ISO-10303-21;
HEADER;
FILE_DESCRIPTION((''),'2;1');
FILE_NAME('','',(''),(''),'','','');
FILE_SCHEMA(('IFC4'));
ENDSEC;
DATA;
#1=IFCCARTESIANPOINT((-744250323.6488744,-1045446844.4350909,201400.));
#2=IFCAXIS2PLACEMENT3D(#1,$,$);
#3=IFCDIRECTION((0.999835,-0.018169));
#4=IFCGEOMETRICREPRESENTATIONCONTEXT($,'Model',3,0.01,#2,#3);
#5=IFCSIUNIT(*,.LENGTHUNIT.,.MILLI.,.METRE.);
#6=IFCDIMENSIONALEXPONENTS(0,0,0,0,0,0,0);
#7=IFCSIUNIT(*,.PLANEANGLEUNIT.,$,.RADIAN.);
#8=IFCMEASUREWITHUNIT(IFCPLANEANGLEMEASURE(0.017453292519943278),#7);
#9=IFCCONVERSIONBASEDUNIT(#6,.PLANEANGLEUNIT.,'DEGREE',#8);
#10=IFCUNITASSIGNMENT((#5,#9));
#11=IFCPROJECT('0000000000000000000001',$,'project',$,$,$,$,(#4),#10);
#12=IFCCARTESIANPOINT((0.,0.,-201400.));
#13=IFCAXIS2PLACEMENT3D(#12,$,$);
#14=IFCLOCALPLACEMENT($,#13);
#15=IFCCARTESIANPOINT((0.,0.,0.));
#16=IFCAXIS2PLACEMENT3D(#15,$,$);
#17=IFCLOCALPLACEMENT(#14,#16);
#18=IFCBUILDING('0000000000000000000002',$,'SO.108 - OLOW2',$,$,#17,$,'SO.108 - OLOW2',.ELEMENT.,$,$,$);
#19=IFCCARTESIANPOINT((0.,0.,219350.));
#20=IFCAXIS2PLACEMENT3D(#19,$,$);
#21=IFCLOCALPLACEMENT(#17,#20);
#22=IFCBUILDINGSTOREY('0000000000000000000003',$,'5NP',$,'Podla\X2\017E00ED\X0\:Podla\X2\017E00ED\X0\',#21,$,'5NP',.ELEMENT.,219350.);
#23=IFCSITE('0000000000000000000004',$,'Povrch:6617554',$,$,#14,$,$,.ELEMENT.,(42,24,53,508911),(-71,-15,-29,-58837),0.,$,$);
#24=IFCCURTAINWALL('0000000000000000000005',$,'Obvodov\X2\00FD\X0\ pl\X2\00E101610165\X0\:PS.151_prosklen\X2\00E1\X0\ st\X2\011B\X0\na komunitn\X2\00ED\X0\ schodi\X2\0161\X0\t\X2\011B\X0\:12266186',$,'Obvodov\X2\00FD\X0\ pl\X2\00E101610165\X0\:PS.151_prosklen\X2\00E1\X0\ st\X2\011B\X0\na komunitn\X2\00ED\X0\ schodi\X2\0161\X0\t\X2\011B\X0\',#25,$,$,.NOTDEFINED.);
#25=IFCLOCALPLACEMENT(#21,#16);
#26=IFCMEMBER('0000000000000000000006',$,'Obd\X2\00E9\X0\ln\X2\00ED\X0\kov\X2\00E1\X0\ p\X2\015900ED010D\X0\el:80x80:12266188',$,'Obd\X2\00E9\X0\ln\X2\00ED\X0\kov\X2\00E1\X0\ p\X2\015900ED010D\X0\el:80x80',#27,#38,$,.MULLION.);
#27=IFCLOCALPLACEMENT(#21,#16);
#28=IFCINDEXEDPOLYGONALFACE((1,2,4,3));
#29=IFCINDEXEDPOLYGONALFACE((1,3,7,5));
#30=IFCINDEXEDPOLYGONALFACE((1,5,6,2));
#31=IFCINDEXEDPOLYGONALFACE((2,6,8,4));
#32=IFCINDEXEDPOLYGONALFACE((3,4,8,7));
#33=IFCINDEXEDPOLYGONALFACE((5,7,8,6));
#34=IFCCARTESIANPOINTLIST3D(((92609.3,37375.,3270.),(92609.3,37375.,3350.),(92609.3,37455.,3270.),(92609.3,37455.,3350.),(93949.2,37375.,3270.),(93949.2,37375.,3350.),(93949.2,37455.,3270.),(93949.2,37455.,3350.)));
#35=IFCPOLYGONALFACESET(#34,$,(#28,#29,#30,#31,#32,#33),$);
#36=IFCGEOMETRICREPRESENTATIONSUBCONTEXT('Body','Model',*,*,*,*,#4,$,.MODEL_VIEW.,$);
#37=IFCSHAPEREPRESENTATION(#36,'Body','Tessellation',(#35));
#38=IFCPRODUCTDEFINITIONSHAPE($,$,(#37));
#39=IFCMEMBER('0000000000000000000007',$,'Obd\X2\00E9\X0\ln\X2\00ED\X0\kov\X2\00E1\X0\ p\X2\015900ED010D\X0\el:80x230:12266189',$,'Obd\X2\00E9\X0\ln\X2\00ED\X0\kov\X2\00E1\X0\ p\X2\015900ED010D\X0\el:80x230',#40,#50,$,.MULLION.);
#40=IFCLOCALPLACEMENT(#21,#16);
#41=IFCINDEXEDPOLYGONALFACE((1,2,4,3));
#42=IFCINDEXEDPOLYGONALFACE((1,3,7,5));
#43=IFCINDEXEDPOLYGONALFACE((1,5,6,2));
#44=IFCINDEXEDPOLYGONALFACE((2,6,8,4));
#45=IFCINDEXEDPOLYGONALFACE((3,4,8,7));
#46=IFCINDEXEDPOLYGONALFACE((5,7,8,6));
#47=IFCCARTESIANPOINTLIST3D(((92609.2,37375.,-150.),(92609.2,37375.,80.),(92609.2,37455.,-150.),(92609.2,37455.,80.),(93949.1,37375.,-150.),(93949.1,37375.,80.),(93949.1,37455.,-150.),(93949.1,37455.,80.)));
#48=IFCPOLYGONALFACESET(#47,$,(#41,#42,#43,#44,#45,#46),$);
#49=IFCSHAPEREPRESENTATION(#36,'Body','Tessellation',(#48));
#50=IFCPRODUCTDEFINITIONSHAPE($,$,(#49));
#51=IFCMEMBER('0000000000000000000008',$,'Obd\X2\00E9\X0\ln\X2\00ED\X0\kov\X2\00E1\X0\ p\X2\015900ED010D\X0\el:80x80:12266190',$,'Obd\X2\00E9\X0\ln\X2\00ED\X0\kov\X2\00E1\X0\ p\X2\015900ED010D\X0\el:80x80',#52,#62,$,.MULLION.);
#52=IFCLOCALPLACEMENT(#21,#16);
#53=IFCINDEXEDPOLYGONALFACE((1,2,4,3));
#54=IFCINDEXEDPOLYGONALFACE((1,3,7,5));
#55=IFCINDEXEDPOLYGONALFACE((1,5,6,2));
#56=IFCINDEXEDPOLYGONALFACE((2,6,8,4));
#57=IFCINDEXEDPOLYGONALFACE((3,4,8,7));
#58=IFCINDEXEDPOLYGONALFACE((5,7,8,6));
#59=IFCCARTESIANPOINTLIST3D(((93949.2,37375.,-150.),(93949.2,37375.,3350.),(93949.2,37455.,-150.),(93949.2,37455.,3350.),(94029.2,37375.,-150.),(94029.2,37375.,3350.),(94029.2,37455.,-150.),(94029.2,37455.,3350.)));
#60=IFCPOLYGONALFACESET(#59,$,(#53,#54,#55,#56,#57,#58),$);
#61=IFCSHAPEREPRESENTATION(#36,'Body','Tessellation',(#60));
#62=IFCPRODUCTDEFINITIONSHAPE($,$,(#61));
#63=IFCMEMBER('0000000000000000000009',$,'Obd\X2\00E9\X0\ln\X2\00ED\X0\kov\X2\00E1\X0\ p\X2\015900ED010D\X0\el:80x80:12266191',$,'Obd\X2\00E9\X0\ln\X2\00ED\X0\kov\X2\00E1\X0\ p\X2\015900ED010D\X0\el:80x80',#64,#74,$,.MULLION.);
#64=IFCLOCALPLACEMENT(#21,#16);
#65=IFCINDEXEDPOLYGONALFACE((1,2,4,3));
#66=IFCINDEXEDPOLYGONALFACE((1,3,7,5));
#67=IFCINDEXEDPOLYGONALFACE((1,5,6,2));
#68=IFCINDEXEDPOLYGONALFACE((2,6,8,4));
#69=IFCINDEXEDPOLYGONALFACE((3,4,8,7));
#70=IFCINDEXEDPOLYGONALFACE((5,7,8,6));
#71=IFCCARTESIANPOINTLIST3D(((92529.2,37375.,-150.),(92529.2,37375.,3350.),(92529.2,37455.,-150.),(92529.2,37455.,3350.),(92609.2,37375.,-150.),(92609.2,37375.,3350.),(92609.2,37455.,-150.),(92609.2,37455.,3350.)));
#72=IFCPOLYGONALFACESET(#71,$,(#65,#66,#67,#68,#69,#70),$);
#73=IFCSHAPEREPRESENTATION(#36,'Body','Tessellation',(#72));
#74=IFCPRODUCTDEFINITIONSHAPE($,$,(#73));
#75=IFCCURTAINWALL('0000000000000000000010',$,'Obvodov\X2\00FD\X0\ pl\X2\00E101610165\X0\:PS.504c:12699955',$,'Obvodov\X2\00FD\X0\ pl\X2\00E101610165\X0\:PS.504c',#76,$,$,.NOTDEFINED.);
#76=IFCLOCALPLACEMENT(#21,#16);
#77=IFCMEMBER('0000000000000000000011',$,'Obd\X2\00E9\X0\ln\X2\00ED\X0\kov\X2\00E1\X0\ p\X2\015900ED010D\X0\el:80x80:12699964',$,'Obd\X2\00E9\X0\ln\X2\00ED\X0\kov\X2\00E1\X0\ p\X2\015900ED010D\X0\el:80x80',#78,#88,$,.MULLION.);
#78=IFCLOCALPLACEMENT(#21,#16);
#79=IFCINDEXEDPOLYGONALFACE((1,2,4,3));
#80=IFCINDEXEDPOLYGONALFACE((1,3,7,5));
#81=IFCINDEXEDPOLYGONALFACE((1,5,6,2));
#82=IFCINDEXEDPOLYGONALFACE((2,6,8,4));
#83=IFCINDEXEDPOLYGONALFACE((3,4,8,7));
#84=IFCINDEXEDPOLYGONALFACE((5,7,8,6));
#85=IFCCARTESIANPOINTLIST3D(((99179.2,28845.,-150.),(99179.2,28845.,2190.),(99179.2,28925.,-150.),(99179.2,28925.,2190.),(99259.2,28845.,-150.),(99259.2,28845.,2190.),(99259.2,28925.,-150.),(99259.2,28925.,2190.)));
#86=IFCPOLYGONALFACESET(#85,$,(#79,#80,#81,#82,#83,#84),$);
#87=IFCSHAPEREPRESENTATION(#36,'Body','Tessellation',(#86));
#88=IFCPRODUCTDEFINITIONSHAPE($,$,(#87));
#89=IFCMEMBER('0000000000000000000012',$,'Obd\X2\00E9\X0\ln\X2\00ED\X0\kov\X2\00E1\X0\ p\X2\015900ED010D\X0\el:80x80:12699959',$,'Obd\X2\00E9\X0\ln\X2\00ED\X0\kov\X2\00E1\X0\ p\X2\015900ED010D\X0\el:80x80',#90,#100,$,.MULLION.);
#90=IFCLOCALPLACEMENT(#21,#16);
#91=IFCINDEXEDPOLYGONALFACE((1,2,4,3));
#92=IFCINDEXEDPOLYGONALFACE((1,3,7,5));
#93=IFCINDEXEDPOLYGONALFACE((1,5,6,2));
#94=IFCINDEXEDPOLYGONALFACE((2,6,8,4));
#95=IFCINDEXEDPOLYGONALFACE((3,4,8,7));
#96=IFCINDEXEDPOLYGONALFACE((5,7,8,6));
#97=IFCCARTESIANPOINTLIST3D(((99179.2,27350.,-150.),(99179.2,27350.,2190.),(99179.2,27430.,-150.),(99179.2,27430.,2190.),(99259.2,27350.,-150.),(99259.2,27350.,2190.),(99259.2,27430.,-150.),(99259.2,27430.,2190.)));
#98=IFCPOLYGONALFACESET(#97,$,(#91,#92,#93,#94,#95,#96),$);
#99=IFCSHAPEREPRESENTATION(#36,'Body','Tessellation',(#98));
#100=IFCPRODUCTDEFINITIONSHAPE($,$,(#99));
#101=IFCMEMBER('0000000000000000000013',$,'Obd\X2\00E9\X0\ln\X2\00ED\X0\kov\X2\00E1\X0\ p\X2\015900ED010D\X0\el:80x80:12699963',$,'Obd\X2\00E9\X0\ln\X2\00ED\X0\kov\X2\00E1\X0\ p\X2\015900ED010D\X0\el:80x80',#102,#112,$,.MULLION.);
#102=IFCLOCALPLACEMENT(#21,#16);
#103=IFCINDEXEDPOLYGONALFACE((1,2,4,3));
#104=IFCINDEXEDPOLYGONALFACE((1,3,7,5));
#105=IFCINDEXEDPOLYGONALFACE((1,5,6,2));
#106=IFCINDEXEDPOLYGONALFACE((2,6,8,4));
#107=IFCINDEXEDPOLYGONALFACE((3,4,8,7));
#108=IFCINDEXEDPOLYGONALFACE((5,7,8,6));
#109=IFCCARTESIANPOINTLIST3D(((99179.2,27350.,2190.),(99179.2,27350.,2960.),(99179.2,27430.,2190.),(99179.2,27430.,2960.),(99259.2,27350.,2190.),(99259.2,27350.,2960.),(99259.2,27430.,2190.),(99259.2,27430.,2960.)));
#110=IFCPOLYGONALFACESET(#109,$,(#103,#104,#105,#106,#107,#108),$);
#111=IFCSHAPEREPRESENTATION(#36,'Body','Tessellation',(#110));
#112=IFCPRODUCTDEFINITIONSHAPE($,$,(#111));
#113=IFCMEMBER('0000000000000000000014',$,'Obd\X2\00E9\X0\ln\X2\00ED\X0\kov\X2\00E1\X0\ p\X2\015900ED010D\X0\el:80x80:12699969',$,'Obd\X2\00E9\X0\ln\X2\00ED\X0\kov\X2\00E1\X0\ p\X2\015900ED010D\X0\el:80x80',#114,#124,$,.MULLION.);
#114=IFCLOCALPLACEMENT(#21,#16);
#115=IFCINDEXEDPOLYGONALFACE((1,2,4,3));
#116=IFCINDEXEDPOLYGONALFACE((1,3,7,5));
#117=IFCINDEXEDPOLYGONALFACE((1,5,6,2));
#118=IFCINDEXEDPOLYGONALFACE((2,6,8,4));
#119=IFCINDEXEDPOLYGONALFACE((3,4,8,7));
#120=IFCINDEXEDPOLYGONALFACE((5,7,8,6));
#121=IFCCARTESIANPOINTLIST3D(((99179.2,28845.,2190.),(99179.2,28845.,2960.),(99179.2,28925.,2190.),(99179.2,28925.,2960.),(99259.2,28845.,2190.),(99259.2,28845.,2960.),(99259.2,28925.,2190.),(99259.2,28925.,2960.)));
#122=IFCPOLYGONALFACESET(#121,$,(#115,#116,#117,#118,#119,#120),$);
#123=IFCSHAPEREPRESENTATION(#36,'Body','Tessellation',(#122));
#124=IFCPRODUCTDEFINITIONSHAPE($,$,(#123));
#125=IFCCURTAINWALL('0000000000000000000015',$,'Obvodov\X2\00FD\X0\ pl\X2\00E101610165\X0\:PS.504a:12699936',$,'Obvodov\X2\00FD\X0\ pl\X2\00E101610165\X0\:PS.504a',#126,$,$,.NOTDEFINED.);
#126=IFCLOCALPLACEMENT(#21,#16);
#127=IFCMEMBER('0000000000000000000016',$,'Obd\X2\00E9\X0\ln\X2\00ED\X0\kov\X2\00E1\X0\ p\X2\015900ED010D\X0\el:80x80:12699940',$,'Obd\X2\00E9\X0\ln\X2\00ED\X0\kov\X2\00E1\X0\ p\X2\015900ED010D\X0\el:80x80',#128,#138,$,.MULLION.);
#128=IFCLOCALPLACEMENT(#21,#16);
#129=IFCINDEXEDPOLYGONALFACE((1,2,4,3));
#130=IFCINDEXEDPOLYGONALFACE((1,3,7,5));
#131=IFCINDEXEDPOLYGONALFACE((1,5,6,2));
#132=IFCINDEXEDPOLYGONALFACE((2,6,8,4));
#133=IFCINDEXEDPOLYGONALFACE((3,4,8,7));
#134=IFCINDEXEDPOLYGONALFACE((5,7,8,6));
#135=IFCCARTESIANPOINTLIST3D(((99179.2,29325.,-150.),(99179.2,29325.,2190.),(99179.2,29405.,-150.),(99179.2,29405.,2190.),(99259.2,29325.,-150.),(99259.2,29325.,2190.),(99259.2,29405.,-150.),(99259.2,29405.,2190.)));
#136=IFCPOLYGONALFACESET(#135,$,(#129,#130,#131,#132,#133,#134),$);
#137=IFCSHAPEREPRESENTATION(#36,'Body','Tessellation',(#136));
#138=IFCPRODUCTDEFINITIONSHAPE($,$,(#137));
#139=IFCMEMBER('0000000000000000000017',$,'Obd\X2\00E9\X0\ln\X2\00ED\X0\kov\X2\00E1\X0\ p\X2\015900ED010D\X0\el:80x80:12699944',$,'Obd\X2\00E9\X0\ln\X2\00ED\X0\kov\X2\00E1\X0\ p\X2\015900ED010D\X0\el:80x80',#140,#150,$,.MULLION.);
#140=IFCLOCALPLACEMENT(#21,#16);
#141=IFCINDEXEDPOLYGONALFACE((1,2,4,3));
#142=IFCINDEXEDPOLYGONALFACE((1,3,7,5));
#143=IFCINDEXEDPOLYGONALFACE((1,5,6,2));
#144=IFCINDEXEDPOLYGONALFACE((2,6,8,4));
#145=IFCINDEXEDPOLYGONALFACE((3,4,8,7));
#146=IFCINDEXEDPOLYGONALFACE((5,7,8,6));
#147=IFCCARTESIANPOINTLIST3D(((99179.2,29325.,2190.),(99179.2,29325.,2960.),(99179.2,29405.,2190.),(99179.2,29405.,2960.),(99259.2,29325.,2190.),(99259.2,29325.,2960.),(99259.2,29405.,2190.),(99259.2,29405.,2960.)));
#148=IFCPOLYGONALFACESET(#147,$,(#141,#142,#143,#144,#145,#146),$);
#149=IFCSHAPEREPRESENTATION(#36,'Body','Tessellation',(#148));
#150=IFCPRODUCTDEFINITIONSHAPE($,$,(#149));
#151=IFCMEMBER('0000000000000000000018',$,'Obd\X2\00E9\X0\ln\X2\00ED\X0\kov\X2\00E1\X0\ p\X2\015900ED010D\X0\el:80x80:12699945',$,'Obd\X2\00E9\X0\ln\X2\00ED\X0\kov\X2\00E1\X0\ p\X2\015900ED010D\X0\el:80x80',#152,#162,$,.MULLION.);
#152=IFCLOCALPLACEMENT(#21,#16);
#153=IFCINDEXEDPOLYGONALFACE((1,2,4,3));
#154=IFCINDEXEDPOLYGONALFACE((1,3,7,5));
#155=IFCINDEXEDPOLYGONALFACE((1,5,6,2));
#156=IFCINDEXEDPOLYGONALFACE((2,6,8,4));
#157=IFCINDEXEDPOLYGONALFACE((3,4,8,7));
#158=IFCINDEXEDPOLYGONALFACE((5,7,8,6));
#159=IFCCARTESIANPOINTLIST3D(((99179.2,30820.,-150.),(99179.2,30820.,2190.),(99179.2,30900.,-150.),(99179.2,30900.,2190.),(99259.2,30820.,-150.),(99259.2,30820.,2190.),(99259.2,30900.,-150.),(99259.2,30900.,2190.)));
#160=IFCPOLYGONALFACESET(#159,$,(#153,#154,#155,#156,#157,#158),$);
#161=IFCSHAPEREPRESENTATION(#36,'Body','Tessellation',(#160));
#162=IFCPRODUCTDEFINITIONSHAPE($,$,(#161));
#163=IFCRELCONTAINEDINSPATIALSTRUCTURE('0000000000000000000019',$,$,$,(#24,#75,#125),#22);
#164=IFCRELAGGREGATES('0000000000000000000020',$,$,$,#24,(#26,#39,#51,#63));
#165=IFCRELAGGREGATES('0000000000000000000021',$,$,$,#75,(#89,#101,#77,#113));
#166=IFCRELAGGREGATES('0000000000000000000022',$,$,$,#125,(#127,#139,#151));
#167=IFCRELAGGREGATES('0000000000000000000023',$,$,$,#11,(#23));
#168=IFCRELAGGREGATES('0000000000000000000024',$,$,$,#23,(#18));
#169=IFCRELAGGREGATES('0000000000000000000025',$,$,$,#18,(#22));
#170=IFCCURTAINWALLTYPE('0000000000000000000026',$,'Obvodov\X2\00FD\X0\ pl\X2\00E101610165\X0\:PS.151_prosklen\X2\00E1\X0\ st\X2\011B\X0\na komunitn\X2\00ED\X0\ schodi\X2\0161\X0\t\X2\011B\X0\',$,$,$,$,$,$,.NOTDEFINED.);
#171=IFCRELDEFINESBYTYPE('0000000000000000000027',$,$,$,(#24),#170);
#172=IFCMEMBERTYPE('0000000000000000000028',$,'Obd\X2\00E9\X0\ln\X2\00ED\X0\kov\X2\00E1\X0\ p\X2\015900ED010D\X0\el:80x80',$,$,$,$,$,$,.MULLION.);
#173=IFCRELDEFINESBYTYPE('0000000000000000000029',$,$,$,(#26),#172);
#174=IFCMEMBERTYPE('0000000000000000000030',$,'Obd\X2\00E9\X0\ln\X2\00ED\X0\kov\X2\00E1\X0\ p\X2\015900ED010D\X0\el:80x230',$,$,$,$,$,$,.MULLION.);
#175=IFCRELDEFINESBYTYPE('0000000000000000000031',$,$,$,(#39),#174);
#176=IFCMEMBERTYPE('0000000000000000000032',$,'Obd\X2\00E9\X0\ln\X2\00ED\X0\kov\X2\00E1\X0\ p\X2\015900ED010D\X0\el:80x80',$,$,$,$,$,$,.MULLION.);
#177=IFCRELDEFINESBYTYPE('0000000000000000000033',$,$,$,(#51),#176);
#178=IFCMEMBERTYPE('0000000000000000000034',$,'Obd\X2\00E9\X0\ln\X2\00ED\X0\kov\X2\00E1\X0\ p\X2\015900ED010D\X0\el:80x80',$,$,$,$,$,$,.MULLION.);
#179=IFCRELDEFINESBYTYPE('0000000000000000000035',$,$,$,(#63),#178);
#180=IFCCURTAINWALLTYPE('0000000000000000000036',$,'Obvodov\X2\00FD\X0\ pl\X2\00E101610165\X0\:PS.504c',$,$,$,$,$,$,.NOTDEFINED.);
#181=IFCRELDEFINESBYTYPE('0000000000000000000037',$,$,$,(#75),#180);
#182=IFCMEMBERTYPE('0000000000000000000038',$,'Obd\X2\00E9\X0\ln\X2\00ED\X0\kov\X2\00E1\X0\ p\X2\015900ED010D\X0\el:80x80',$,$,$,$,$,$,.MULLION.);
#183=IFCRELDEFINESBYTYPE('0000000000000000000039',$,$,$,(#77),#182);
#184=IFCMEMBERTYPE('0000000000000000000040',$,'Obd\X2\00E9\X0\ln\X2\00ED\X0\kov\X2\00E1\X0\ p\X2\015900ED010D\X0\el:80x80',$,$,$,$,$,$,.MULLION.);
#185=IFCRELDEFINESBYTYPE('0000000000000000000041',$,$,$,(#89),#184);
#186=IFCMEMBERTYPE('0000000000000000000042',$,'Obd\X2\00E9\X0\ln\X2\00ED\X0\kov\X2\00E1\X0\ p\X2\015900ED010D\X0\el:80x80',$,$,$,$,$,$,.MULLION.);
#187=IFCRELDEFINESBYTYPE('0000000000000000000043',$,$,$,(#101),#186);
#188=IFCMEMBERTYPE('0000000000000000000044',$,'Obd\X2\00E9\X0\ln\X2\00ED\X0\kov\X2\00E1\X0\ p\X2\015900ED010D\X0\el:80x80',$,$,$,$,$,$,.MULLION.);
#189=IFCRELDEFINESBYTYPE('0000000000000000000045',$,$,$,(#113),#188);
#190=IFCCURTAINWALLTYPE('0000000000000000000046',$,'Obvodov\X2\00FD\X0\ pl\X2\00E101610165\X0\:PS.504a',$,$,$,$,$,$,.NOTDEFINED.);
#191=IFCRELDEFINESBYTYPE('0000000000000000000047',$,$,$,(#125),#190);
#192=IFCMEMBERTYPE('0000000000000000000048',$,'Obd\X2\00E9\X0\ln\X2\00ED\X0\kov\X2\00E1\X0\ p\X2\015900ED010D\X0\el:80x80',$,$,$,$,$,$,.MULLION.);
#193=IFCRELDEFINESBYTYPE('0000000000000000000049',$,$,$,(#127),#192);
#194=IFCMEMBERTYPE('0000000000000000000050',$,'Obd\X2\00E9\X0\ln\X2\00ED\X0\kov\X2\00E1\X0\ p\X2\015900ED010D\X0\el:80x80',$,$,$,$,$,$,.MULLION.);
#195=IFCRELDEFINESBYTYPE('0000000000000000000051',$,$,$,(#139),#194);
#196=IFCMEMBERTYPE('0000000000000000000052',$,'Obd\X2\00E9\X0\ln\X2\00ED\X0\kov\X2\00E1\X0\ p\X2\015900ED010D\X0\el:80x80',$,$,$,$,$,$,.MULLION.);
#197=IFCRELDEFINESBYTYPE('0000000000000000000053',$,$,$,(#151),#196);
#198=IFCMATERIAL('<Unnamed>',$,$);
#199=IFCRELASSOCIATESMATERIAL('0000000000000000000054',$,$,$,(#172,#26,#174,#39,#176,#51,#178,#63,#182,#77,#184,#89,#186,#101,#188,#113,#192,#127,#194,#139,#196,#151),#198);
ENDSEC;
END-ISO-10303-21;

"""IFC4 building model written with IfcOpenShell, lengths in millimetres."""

from ifc_helpers import new_model, entity, si_unit, converted_unit, direction, frame, origin, place, context, subcontext, project, spatial, indexed_curve, outline, extrude, source, transform, mapped, material, type_object, type_shapes, element, aggregate, save


model = new_model("IFC4")

# Units and contexts
model_context = context("Model", 3, precision=0.01, world=frame((-744250323.6488744, -1045446844.4350909, 201400.0)), true_north=direction((0.999835, -0.018169)))
body_context = subcontext(model_context, "Body", "Model", "MODEL_VIEW")
ifc_project = project(units=[si_unit("LENGTHUNIT", "METRE", prefix="MILLI"), converted_unit("PLANEANGLEUNIT", "DEGREE", entity("IfcPlaneAngleMeasure", 0.017453292519943278), si_unit("PLANEANGLEUNIT", "RADIAN"), dimensions=[0, 0, 0, 0, 0, 0, 0])], contexts=[model_context])

# Site, building, storey
site_placement = place(None, frame((0.0, 0.0, -201400.0)))
site = spatial("IfcSite", under=ifc_project, at=site_placement, Name="Povrch:6617554", CompositionType="ELEMENT", RefLatitude=(42, 24, 53, 508911), RefLongitude=(-71, -15, -29, -58837), RefElevation=0.0)
building_placement = place(site_placement, origin())
building = spatial("IfcBuilding", under=site, at=building_placement, Name="SO.108 - OLOW2", LongName="SO.108 - OLOW2", CompositionType="ELEMENT")
storey_placement = place(building_placement, frame((0.0, 0.0, 219350.0)))
storey = spatial("IfcBuildingStorey", under=building, at=storey_placement, Name="5NP", ObjectType="Podlaží:Podlaží", LongName="5NP", CompositionType="ELEMENT", Elevation=219350.0)

# Curtain walls, members
curtain_wall_type_1 = type_object("IfcCurtainWallType", Name="Obvodový plášť:PS.151_prosklená stěna komunitní schodiště", PredefinedType="NOTDEFINED")
curtain_wall_1_placement = place(storey_placement, frame((0.0, 0.0, -219350.0)))
curtain_wall_1 = element("IfcCurtainWall", 1, at=curtain_wall_1_placement, inside=storey, type_object=curtain_wall_type_1, Name="Obvodový plášť:PS.151_prosklená stěna komunitní schodiště:12266186", ObjectType="Obvodový plášť:PS.151_prosklená stěna komunitní schodiště", PredefinedType="NOTDEFINED")
ifc_material_1 = material(Name="<Unnamed>")
member_type_1 = type_object("IfcMemberType", Name="Obdélníková příčel:80x80", PredefinedType="MULLION", material=ifc_material_1)
shared_shape_1 = source(origin(), body_context, "Body", "SweptSolid", [
    extrude(outline(indexed_curve([(-40.0, -40.0), (40.0, -40.0), (40.0, 40.0), (-40.0, 40.0), (-40.0, -40.0)], self_intersect=False)), frame((-40.0, 0.0, -1339.9), z_axis=(0.0, 0.0, 1.0), x_axis=(-1.0, 0.0, 0.0)), (0.0, 0.0, 1.0), 1339.9),
])
type_shapes(member_type_1, [shared_shape_1])
member_1_placement = place(curtain_wall_1_placement, frame((93949.2, 37415.0, 222700.0), z_axis=(1.0, 0.0, 0.0), x_axis=(0.0, 0.0, 1.0)))
member_1 = element("IfcMember", 2, at=member_1_placement, type_object=member_type_1, material=ifc_material_1, Name="Obdélníková příčel:80x80:12266188", ObjectType="Obdélníková příčel:80x80", PredefinedType="MULLION", context=body_context, shape_type="MappedRepresentation", body=[
    mapped(shared_shape_1, transform((0.0, 0.0, 0.0), scale=1.0)),
])
member_type_2 = type_object("IfcMemberType", Name="Obdélníková příčel:80x230", PredefinedType="MULLION", material=ifc_material_1)
shared_shape_2 = source(origin(), body_context, "Body", "SweptSolid", [
    extrude(outline(indexed_curve([(-115.0, -40.0), (115.0, -40.0), (115.0, 40.0), (-115.0, 40.0), (-115.0, -40.0)], self_intersect=False)), frame((-115.0, 0.0, -1339.9), z_axis=(0.0, 0.0, 1.0), x_axis=(-1.0, 0.0, 0.0)), (0.0, 0.0, 1.0), 1339.9),
])
type_shapes(member_type_2, [shared_shape_2])
member_2_placement = place(curtain_wall_1_placement, frame((92609.2, 37415.0, 219200.0), z_axis=(-1.0, 0.0, 0.0), x_axis=(0.0, 0.0, -1.0)))
member_2 = element("IfcMember", 3, at=member_2_placement, type_object=member_type_2, material=ifc_material_1, Name="Obdélníková příčel:80x230:12266189", ObjectType="Obdélníková příčel:80x230", PredefinedType="MULLION", context=body_context, shape_type="MappedRepresentation", body=[
    mapped(shared_shape_2, transform((0.0, 0.0, 0.0), scale=1.0)),
])
member_type_3 = type_object("IfcMemberType", Name="Obdélníková příčel:80x80", PredefinedType="MULLION", material=ifc_material_1)
shared_shape_3 = source(origin(), body_context, "Body", "SweptSolid", [
    extrude(outline(indexed_curve([(-40.0, -40.0), (40.0, -40.0), (40.0, 40.0), (-40.0, 40.0), (-40.0, -40.0)], self_intersect=False)), frame((-40.0, 0.0, -3500.0), z_axis=(0.0, 0.0, 1.0), x_axis=(-1.0, 0.0, 0.0)), (0.0, 0.0, 1.0), 3500.0),
])
type_shapes(member_type_3, [shared_shape_3])
member_3_placement = place(curtain_wall_1_placement, frame((94029.2, 37415.0, 219200.0), z_axis=(0.0, 0.0, -1.0), x_axis=(1.0, 0.0, 0.0)))
member_3 = element("IfcMember", 4, at=member_3_placement, type_object=member_type_3, material=ifc_material_1, Name="Obdélníková příčel:80x80:12266190", ObjectType="Obdélníková příčel:80x80", PredefinedType="MULLION", context=body_context, shape_type="MappedRepresentation", body=[
    mapped(shared_shape_3, transform((0.0, 0.0, 0.0), scale=1.0)),
])
member_type_4 = type_object("IfcMemberType", Name="Obdélníková příčel:80x80", PredefinedType="MULLION", material=ifc_material_1)
shared_shape_4 = source(origin(), body_context, "Body", "SweptSolid", [
    extrude(outline(indexed_curve([(-40.0, -40.0), (40.0, -40.0), (40.0, 40.0), (-40.0, 40.0), (-40.0, -40.0)], self_intersect=False)), frame((-40.0, 0.0, -3500.0), z_axis=(0.0, 0.0, 1.0), x_axis=(-1.0, 0.0, 0.0)), (0.0, 0.0, 1.0), 3500.0),
])
type_shapes(member_type_4, [shared_shape_4])
member_4_placement = place(curtain_wall_1_placement, frame((92529.2, 37415.0, 222700.0), z_axis=(0.0, 0.0, 1.0), x_axis=(-1.0, 0.0, 0.0)))
member_4 = element("IfcMember", 5, at=member_4_placement, type_object=member_type_4, material=ifc_material_1, Name="Obdélníková příčel:80x80:12266191", ObjectType="Obdélníková příčel:80x80", PredefinedType="MULLION", context=body_context, shape_type="MappedRepresentation", body=[
    mapped(shared_shape_4, transform((0.0, 0.0, 0.0), scale=1.0)),
])
curtain_wall_type_2 = type_object("IfcCurtainWallType", Name="Obvodový plášť:PS.504c", PredefinedType="NOTDEFINED")
curtain_wall_2_placement = place(storey_placement, frame((0.0, 0.0, -219350.0)))
curtain_wall_2 = element("IfcCurtainWall", 6, at=curtain_wall_2_placement, inside=storey, type_object=curtain_wall_type_2, Name="Obvodový plášť:PS.504c:12699955", ObjectType="Obvodový plášť:PS.504c", PredefinedType="NOTDEFINED")
member_type_5 = type_object("IfcMemberType", Name="Obdélníková příčel:80x80", PredefinedType="MULLION", material=ifc_material_1)
shared_shape_5 = source(origin(), body_context, "Body", "SweptSolid", [
    extrude(outline(indexed_curve([(-40.0, -40.0), (40.0, -40.0), (40.0, 40.0), (-40.0, 40.0), (-40.0, -40.0)], self_intersect=False)), frame((-40.0, 0.0, -2340.0), z_axis=(0.0, 0.0, 1.0), x_axis=(-1.0, 0.0, 0.0)), (0.0, 0.0, 1.0), 2340.0),
])
type_shapes(member_type_5, [shared_shape_5])
member_5_placement = place(curtain_wall_2_placement, frame((99219.2, 28925.0, 221540.0), z_axis=(0.0, 0.0, 1.0), x_axis=(0.0, 1.0, 0.0)))
member_5 = element("IfcMember", 7, at=member_5_placement, type_object=member_type_5, material=ifc_material_1, Name="Obdélníková příčel:80x80:12699964", ObjectType="Obdélníková příčel:80x80", PredefinedType="MULLION", context=body_context, shape_type="MappedRepresentation", body=[
    mapped(shared_shape_5, transform((0.0, 0.0, 0.0), scale=1.0)),
])
member_type_6 = type_object("IfcMemberType", Name="Obdélníková příčel:80x80", PredefinedType="MULLION", material=ifc_material_1)
shared_shape_6 = source(origin(), body_context, "Body", "SweptSolid", [
    extrude(outline(indexed_curve([(-40.0, -40.0), (40.0, -40.0), (40.0, 40.0), (-40.0, 40.0), (-40.0, -40.0)], self_intersect=False)), frame((-40.0, 0.0, -2340.0), z_axis=(0.0, 0.0, 1.0), x_axis=(-1.0, 0.0, 0.0)), (0.0, 0.0, 1.0), 2340.0),
])
type_shapes(member_type_6, [shared_shape_6])
member_6_placement = place(curtain_wall_2_placement, frame((99219.2, 27350.0, 219200.0), z_axis=(0.0, 0.0, -1.0), x_axis=(0.0, -1.0, 0.0)))
member_6 = element("IfcMember", 8, at=member_6_placement, type_object=member_type_6, material=ifc_material_1, Name="Obdélníková příčel:80x80:12699959", ObjectType="Obdélníková příčel:80x80", PredefinedType="MULLION", context=body_context, shape_type="MappedRepresentation", body=[
    mapped(shared_shape_6, transform((0.0, 0.0, 0.0), scale=1.0)),
])
member_type_7 = type_object("IfcMemberType", Name="Obdélníková příčel:80x80", PredefinedType="MULLION", material=ifc_material_1)
shared_shape_7 = source(origin(), body_context, "Body", "SweptSolid", [
    extrude(outline(indexed_curve([(-40.0, -40.0), (40.0, -40.0), (40.0, 40.0), (-40.0, 40.0), (-40.0, -40.0)], self_intersect=False)), frame((-40.0, 0.0, -770.0), z_axis=(0.0, 0.0, 1.0), x_axis=(-1.0, 0.0, 0.0)), (0.0, 0.0, 1.0), 770.0),
])
type_shapes(member_type_7, [shared_shape_7])
member_7_placement = place(curtain_wall_2_placement, frame((99219.2, 27350.0, 221540.0), z_axis=(0.0, 0.0, -1.0), x_axis=(0.0, -1.0, 0.0)))
member_7 = element("IfcMember", 9, at=member_7_placement, type_object=member_type_7, material=ifc_material_1, Name="Obdélníková příčel:80x80:12699963", ObjectType="Obdélníková příčel:80x80", PredefinedType="MULLION", context=body_context, shape_type="MappedRepresentation", body=[
    mapped(shared_shape_7, transform((0.0, 0.0, 0.0), scale=1.0)),
])
member_type_8 = type_object("IfcMemberType", Name="Obdélníková příčel:80x80", PredefinedType="MULLION", material=ifc_material_1)
shared_shape_8 = source(origin(), body_context, "Body", "SweptSolid", [
    extrude(outline(indexed_curve([(-40.0, -40.0), (40.0, -40.0), (40.0, 40.0), (-40.0, 40.0), (-40.0, -40.0)], self_intersect=False)), frame((-40.0, 0.0, -770.0), z_axis=(0.0, 0.0, 1.0), x_axis=(-1.0, 0.0, 0.0)), (0.0, 0.0, 1.0), 770.0),
])
type_shapes(member_type_8, [shared_shape_8])
member_8_placement = place(curtain_wall_2_placement, frame((99219.2, 28925.0, 222310.0), z_axis=(0.0, 0.0, 1.0), x_axis=(0.0, 1.0, 0.0)))
member_8 = element("IfcMember", 10, at=member_8_placement, type_object=member_type_8, material=ifc_material_1, Name="Obdélníková příčel:80x80:12699969", ObjectType="Obdélníková příčel:80x80", PredefinedType="MULLION", context=body_context, shape_type="MappedRepresentation", body=[
    mapped(shared_shape_8, transform((0.0, 0.0, 0.0), scale=1.0)),
])
curtain_wall_type_3 = type_object("IfcCurtainWallType", Name="Obvodový plášť:PS.504a", PredefinedType="NOTDEFINED")
curtain_wall_3_placement = place(storey_placement, frame((0.0, 0.0, -219350.0)))
curtain_wall_3 = element("IfcCurtainWall", 11, at=curtain_wall_3_placement, inside=storey, type_object=curtain_wall_type_3, Name="Obvodový plášť:PS.504a:12699936", ObjectType="Obvodový plášť:PS.504a", PredefinedType="NOTDEFINED")
member_type_9 = type_object("IfcMemberType", Name="Obdélníková příčel:80x80", PredefinedType="MULLION", material=ifc_material_1)
shared_shape_9 = source(origin(), body_context, "Body", "SweptSolid", [
    extrude(outline(indexed_curve([(-40.0, -40.0), (40.0, -40.0), (40.0, 40.0), (-40.0, 40.0), (-40.0, -40.0)], self_intersect=False)), frame((-40.0, 0.0, -2340.0), z_axis=(0.0, 0.0, 1.0), x_axis=(-1.0, 0.0, 0.0)), (0.0, 0.0, 1.0), 2340.0),
])
type_shapes(member_type_9, [shared_shape_9])
member_9_placement = place(curtain_wall_3_placement, frame((99219.2, 29325.0, 219200.0), z_axis=(0.0, 0.0, -1.0), x_axis=(0.0, -1.0, 0.0)))
member_9 = element("IfcMember", 12, at=member_9_placement, type_object=member_type_9, material=ifc_material_1, Name="Obdélníková příčel:80x80:12699940", ObjectType="Obdélníková příčel:80x80", PredefinedType="MULLION", context=body_context, shape_type="MappedRepresentation", body=[
    mapped(shared_shape_9, transform((0.0, 0.0, 0.0), scale=1.0)),
])
member_type_10 = type_object("IfcMemberType", Name="Obdélníková příčel:80x80", PredefinedType="MULLION", material=ifc_material_1)
shared_shape_10 = source(origin(), body_context, "Body", "SweptSolid", [
    extrude(outline(indexed_curve([(-40.0, -40.0), (40.0, -40.0), (40.0, 40.0), (-40.0, 40.0), (-40.0, -40.0)], self_intersect=False)), frame((-40.0, 0.0, -770.0), z_axis=(0.0, 0.0, 1.0), x_axis=(-1.0, 0.0, 0.0)), (0.0, 0.0, 1.0), 770.0),
])
type_shapes(member_type_10, [shared_shape_10])
member_10_placement = place(curtain_wall_3_placement, frame((99219.2, 29325.0, 221540.0), z_axis=(0.0, 0.0, -1.0), x_axis=(0.0, -1.0, 0.0)))
member_10 = element("IfcMember", 13, at=member_10_placement, type_object=member_type_10, material=ifc_material_1, Name="Obdélníková příčel:80x80:12699944", ObjectType="Obdélníková příčel:80x80", PredefinedType="MULLION", context=body_context, shape_type="MappedRepresentation", body=[
    mapped(shared_shape_10, transform((0.0, 0.0, 0.0), scale=1.0)),
])
member_type_11 = type_object("IfcMemberType", Name="Obdélníková příčel:80x80", PredefinedType="MULLION", material=ifc_material_1)
shared_shape_11 = source(origin(), body_context, "Body", "SweptSolid", [
    extrude(outline(indexed_curve([(-40.0, -40.0), (40.0, -40.0), (40.0, 40.0), (-40.0, 40.0), (-40.0, -40.0)], self_intersect=False)), frame((-40.0, 0.0, -2340.0), z_axis=(0.0, 0.0, 1.0), x_axis=(-1.0, 0.0, 0.0)), (0.0, 0.0, 1.0), 2340.0),
])
type_shapes(member_type_11, [shared_shape_11])
member_11_placement = place(curtain_wall_3_placement, frame((99219.2, 30900.0, 221540.0), z_axis=(0.0, 0.0, 1.0), x_axis=(0.0, 1.0, 0.0)))
member_11 = element("IfcMember", 14, at=member_11_placement, type_object=member_type_11, material=ifc_material_1, Name="Obdélníková příčel:80x80:12699945", ObjectType="Obdélníková příčel:80x80", PredefinedType="MULLION", context=body_context, shape_type="MappedRepresentation", body=[
    mapped(shared_shape_11, transform((0.0, 0.0, 0.0), scale=1.0)),
])

aggregate(curtain_wall_1, [member_1, member_2, member_3, member_4])
aggregate(curtain_wall_2, [member_6, member_7, member_5, member_8])

aggregate(curtain_wall_3, [member_9, member_10, member_11])

save(model, "model.ifc")
